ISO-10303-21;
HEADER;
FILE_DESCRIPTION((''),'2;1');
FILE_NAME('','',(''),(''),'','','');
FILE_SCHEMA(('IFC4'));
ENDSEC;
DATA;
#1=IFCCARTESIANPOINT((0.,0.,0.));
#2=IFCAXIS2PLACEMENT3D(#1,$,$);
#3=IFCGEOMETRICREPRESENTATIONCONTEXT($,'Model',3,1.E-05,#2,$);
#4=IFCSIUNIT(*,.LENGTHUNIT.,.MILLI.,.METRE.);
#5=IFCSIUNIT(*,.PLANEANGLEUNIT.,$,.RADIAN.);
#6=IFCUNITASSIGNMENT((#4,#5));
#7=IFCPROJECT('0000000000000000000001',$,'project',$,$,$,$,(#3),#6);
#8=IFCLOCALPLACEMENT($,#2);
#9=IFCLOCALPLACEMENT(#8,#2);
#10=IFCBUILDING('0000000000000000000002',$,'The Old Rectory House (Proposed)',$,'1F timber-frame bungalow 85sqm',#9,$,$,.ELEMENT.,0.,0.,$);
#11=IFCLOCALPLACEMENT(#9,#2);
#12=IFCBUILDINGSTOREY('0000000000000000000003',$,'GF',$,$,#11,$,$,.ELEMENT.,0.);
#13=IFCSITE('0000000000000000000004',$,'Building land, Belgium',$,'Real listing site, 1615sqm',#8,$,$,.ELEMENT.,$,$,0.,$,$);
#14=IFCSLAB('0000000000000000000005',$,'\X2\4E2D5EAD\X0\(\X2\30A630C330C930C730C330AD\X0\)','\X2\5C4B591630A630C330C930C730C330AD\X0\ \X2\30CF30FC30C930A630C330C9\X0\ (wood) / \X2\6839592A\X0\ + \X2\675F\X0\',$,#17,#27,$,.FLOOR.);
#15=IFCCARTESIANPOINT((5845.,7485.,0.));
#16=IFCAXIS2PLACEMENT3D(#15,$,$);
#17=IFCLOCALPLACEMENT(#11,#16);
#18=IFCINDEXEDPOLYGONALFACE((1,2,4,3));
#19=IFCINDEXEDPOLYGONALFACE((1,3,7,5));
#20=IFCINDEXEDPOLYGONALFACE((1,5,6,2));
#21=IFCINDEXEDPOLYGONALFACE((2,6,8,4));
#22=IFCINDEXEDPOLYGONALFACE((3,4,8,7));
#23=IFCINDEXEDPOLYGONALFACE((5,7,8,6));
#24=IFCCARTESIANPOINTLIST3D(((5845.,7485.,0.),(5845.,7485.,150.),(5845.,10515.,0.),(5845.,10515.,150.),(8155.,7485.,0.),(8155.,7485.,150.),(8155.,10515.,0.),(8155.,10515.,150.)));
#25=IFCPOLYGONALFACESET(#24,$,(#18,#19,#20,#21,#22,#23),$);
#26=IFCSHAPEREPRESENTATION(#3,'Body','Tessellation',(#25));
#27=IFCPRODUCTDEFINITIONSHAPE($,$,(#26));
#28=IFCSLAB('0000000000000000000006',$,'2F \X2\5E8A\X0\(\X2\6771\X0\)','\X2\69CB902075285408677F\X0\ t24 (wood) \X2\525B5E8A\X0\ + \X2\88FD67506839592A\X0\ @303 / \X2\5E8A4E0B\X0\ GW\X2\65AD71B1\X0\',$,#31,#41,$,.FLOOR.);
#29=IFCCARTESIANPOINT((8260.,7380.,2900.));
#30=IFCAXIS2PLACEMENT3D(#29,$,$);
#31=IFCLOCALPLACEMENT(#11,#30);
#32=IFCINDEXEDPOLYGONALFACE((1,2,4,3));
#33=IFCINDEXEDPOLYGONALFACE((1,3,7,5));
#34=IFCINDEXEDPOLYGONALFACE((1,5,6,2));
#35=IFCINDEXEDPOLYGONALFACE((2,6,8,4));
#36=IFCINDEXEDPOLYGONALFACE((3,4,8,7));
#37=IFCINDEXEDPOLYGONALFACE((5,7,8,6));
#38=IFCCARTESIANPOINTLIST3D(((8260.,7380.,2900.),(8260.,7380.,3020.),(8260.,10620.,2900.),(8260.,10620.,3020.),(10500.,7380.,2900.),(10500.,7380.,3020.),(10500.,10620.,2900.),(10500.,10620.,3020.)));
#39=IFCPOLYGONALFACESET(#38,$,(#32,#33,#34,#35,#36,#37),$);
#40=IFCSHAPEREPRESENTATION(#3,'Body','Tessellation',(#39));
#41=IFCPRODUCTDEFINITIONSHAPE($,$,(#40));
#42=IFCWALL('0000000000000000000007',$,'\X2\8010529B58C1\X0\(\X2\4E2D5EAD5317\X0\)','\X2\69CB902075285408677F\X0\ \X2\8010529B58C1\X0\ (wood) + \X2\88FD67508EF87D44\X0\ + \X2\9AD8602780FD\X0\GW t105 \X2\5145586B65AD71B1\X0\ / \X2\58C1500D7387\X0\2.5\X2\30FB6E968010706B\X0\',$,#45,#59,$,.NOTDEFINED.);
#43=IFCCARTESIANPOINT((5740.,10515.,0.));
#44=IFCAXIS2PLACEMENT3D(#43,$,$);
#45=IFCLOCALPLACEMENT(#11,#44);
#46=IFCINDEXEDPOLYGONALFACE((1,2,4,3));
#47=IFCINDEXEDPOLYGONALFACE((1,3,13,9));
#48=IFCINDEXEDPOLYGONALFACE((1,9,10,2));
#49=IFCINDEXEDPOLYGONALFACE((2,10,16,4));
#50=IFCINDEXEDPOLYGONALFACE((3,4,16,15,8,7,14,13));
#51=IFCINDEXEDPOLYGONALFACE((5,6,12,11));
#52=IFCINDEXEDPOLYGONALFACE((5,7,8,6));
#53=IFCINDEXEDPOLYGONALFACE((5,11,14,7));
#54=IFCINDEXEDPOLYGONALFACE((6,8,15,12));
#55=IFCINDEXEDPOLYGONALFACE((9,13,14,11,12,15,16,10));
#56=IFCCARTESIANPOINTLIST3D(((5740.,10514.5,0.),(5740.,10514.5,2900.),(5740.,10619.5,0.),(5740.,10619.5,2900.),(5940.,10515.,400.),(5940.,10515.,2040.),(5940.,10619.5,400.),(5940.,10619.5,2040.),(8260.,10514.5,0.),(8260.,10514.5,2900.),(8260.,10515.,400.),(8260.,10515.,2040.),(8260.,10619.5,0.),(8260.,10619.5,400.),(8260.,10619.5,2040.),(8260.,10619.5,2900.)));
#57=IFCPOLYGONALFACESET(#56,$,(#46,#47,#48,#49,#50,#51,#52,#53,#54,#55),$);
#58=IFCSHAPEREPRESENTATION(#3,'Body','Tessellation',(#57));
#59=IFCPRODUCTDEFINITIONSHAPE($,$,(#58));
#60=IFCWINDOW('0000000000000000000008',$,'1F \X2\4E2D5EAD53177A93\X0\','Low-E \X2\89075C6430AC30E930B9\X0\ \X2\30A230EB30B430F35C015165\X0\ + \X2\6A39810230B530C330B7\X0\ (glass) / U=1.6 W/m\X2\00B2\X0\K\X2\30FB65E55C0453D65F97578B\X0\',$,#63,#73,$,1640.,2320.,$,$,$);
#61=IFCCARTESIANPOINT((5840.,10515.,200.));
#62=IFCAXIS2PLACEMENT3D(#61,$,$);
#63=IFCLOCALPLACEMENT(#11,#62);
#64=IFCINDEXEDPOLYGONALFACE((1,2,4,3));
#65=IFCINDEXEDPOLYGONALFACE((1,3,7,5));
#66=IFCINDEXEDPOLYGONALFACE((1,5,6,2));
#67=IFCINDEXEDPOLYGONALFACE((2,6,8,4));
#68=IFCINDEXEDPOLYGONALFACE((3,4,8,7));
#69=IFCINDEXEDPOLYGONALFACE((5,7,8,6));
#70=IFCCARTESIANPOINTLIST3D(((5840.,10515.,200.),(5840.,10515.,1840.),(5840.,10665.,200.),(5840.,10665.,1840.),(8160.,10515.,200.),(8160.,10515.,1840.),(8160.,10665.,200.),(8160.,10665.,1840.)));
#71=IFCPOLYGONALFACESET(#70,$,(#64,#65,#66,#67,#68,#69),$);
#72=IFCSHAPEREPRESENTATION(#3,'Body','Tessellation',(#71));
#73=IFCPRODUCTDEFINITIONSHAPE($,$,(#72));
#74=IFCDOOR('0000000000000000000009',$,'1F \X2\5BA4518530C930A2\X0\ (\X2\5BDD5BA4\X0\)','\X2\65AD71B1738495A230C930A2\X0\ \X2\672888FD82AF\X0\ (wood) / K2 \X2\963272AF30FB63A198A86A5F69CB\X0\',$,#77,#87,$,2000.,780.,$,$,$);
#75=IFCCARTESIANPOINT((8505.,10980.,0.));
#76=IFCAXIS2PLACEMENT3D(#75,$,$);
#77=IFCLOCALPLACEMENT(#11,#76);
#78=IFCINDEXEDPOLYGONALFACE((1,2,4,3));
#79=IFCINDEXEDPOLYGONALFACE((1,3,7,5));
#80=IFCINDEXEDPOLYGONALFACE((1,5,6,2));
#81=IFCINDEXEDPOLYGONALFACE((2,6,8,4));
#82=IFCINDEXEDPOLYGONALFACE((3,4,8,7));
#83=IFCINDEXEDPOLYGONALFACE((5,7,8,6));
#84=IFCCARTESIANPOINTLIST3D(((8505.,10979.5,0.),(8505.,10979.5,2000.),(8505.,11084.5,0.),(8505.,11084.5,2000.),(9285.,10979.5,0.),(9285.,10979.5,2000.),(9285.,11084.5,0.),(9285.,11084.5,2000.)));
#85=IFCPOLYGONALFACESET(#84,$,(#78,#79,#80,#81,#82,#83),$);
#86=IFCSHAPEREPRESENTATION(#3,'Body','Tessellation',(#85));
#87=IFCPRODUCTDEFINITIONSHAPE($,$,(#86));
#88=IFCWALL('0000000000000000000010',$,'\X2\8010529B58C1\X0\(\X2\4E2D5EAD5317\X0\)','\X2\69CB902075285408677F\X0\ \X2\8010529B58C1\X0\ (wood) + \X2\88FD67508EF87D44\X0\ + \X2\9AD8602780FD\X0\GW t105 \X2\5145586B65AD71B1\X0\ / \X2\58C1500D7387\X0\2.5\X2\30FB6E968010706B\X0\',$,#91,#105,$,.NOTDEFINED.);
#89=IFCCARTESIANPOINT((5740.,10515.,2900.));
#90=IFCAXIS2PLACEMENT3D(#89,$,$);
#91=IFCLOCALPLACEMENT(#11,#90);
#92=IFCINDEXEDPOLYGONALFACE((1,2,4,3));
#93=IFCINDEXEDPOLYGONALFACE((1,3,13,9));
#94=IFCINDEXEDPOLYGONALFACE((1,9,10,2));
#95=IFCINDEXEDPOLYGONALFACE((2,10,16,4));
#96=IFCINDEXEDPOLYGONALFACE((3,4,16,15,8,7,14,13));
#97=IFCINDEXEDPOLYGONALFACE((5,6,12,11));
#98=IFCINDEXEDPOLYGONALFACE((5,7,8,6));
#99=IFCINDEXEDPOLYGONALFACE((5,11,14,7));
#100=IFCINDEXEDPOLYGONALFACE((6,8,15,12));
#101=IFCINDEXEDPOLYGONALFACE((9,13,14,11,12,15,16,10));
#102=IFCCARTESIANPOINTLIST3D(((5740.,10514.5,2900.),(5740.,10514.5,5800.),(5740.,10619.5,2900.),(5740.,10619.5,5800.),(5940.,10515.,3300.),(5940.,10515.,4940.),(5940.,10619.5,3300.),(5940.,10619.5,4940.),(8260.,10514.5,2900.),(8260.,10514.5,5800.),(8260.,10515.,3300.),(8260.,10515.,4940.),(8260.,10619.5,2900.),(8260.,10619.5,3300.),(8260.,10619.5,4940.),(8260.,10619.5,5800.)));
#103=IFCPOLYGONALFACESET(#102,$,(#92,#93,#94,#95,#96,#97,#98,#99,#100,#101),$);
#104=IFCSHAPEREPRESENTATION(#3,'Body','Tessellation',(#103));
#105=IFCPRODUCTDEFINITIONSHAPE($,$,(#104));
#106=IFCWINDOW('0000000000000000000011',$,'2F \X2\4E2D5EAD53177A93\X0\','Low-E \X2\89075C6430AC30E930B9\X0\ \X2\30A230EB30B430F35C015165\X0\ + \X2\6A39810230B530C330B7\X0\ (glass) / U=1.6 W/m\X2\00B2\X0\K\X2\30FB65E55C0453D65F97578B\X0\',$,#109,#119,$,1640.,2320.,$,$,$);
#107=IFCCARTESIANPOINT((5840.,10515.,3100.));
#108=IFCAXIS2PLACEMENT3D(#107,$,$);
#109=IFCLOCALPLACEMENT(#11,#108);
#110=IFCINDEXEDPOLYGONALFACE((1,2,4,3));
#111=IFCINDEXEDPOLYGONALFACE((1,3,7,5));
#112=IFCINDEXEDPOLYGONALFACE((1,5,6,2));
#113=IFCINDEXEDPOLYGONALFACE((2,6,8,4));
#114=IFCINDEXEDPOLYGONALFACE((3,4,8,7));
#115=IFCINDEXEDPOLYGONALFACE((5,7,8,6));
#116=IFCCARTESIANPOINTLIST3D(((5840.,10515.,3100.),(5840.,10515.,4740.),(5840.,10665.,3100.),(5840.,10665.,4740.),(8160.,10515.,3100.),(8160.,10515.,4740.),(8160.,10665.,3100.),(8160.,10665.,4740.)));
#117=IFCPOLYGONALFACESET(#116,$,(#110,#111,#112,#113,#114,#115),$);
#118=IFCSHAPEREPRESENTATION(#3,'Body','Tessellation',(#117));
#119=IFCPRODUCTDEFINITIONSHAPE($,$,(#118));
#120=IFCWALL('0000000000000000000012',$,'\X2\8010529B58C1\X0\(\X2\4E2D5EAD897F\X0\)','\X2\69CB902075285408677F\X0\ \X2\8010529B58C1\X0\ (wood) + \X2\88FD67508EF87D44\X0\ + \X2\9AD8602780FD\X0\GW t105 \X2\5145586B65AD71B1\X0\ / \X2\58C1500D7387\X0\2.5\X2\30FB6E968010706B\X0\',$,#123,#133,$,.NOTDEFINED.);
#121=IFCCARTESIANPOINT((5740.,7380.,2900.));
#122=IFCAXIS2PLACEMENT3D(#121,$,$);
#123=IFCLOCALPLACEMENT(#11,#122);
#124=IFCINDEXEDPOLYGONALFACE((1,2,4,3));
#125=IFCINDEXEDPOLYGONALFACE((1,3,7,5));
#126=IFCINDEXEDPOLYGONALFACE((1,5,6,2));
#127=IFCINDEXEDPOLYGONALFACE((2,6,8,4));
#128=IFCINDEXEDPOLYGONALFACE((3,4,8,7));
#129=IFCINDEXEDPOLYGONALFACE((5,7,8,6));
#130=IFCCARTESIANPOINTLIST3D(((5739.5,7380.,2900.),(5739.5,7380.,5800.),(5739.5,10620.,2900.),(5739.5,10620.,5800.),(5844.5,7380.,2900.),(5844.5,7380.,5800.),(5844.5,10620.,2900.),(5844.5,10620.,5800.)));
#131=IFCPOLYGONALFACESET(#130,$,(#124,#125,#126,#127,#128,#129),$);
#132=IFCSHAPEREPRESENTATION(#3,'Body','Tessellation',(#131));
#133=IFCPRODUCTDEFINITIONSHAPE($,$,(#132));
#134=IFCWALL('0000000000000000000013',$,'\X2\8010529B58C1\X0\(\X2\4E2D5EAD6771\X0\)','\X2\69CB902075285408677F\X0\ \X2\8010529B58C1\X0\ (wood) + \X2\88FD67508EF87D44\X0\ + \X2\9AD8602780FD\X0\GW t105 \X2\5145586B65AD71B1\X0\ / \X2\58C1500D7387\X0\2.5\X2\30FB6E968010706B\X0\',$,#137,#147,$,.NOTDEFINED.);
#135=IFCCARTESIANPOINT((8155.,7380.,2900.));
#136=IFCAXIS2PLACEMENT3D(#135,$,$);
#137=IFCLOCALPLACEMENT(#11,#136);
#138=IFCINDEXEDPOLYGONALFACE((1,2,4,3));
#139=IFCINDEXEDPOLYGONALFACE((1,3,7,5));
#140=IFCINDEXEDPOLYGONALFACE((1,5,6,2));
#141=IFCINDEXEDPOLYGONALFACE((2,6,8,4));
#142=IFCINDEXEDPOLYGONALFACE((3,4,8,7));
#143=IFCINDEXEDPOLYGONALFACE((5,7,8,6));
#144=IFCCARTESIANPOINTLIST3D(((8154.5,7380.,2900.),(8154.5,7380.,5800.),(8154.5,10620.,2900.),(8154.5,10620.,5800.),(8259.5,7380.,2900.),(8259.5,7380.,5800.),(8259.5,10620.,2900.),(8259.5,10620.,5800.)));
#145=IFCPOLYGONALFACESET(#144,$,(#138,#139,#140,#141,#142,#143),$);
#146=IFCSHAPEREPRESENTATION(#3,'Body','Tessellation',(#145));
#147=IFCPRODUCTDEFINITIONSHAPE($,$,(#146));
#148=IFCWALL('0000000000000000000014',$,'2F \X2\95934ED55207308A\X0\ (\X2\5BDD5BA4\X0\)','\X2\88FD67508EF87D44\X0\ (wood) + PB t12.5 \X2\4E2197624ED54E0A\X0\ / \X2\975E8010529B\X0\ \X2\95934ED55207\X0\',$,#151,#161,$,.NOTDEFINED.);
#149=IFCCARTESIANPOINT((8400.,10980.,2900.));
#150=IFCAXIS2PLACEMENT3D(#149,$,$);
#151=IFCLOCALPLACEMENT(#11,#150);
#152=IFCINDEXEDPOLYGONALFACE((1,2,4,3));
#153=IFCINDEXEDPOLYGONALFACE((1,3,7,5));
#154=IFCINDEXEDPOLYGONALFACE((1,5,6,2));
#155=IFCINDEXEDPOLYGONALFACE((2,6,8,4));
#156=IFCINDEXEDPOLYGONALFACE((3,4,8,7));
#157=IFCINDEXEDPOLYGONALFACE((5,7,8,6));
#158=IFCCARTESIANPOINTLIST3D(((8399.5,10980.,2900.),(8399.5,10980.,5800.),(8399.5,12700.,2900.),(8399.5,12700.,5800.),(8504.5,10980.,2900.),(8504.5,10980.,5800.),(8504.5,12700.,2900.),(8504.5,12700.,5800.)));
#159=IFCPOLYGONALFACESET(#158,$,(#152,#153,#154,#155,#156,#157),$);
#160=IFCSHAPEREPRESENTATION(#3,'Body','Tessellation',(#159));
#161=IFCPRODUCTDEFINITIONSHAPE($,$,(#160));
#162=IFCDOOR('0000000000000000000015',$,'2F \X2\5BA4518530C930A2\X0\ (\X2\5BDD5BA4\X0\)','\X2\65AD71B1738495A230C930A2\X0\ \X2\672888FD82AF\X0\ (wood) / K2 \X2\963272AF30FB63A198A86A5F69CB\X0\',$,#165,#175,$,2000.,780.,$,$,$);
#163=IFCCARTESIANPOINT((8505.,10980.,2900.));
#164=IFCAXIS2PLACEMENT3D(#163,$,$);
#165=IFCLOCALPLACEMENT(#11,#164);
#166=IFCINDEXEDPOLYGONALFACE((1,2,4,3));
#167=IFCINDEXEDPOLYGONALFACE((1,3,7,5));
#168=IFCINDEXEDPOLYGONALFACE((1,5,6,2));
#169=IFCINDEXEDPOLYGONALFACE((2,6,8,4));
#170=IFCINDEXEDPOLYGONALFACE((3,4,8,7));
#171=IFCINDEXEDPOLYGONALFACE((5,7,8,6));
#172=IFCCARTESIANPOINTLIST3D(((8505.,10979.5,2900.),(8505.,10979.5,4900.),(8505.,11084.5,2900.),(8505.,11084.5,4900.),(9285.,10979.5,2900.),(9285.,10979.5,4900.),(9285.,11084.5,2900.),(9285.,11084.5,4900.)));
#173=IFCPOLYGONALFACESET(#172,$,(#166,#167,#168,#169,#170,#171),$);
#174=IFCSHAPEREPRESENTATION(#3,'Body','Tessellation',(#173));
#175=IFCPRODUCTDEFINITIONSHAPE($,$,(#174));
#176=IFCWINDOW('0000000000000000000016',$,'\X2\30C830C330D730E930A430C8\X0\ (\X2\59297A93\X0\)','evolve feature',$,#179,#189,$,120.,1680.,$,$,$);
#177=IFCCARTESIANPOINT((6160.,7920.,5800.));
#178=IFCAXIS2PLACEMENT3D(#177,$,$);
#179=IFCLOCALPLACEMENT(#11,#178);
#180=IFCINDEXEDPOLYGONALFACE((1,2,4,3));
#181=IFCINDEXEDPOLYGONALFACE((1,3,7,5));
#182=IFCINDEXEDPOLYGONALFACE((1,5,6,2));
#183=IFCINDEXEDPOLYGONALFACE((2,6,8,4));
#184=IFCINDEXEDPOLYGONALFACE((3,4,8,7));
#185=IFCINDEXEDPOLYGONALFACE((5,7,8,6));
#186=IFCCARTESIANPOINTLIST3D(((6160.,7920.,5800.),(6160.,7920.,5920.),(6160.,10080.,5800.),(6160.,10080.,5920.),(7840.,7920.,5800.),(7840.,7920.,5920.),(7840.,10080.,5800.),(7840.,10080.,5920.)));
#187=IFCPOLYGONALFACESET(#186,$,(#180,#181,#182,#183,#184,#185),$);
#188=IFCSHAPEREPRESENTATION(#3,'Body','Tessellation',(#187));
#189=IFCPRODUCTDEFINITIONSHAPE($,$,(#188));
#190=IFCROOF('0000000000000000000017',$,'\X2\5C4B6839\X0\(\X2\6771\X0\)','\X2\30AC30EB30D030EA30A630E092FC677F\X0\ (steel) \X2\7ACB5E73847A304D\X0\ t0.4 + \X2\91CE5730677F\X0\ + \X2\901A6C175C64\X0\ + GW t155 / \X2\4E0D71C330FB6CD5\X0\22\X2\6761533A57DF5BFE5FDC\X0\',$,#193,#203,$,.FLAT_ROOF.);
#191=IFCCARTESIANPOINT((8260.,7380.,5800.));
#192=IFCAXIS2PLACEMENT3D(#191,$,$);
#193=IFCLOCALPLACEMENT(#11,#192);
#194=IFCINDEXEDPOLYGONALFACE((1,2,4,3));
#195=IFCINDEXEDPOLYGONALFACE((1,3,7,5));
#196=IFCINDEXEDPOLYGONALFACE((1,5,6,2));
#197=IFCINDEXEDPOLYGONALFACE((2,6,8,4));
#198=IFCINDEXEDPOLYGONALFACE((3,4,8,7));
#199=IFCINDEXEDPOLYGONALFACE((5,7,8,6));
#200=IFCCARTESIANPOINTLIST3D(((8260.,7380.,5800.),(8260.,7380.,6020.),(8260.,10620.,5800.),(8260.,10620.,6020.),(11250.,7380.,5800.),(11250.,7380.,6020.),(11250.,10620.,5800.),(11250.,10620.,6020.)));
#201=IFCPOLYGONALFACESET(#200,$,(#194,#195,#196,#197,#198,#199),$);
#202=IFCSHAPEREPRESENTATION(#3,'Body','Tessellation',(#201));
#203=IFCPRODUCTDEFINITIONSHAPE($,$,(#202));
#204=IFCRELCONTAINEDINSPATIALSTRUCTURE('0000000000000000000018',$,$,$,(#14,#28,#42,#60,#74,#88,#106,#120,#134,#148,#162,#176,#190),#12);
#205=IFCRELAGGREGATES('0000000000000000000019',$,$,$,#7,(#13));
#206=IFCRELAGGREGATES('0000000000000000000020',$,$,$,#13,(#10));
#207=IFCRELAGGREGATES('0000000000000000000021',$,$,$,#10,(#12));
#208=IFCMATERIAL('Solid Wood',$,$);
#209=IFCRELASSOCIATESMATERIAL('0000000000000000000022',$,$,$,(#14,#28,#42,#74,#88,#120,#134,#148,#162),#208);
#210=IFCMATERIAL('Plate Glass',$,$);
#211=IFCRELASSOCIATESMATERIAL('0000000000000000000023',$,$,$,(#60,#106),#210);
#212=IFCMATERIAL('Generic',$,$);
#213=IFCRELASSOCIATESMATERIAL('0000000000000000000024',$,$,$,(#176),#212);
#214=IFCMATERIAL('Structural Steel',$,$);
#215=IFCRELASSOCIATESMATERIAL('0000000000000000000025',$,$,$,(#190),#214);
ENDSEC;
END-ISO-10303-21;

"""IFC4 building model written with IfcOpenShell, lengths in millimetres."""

from ifc_helpers import new_model, si_unit, frame, frame_2d, origin, place, context, project, spatial, rectangle, extrude, material, element, fill, save


model = new_model("IFC4")

# Units and contexts
model_context = context("Model", 3, precision=1e-05, world=origin())
ifc_project = project(units=[si_unit("LENGTHUNIT", "METRE", prefix="MILLI"), si_unit("PLANEANGLEUNIT", "RADIAN")], contexts=[model_context])

# Site, building, storey
site_placement = place(None, origin())
site = spatial("IfcSite", under=ifc_project, at=site_placement, Name="Building land, Belgium", ObjectType="Real listing site, 1615sqm", CompositionType="ELEMENT", RefElevation=0.0)
building_placement = place(site_placement, origin())
building = spatial("IfcBuilding", under=site, at=building_placement, Name="The Old Rectory House (Proposed)", ObjectType="1F timber-frame bungalow 85sqm", CompositionType="ELEMENT", ElevationOfRefHeight=0.0, ElevationOfTerrain=0.0)
storey_placement = place(building_placement, origin())
storey = spatial("IfcBuildingStorey", under=building, at=storey_placement, Name="GF", CompositionType="ELEMENT", Elevation=0.0)

# Slabs
ifc_material_1 = material(Name="Solid Wood")
slab_1_placement = place(storey_placement, frame((5845.0, 7485.0, 0.0)))
element("IfcSlab", 1, at=slab_1_placement, inside=storey, material=ifc_material_1, Name="中庭(ウッドデッキ)", Description="屋外ウッドデッキ ハードウッド (wood) / 根太 + 束", PredefinedType="FLOOR", context=model_context, shape_type="SweptSolid", body=[
    extrude(rectangle(XDim=2310.0, YDim=3030.0, at=frame_2d((1155.0, 1515.0))), frame((5845.0, 7485.0, 0.0)), (0.0, 0.0, 1.0), 150.0),
])
slab_2_placement = place(storey_placement, frame((8260.0, 7380.0, 2900.0)))
element("IfcSlab", 2, at=slab_2_placement, inside=storey, material=ifc_material_1, Name="2F 床(東)", Description="構造用合板 t24 (wood) 剛床 + 製材根太 @303 / 床下 GW断熱", PredefinedType="FLOOR", context=model_context, shape_type="SweptSolid", body=[
    extrude(rectangle(XDim=2240.0, YDim=3240.0, at=frame_2d((1120.0, 1620.0))), frame((8260.0, 7380.0, 2900.0)), (0.0, 0.0, 1.0), 120.0),
])

# Wall, opening, window
wall_1_placement = place(storey_placement, frame((5740.0, 10515.0, 0.0)))
wall_1 = element("IfcWall", 3, at=wall_1_placement, inside=storey, material=ifc_material_1, Name="耐力壁(中庭北)", Description="構造用合板 耐力壁 (wood) + 製材軸組 + 高性能GW t105 充填断熱 / 壁倍率2.5・準耐火", PredefinedType="NOTDEFINED", context=model_context, shape_type="SweptSolid", body=[
    extrude(rectangle(XDim=2520.0, YDim=105.0, at=frame_2d((1260.0, 52.0))), frame((5740.0, 10515.0, 0.0)), (0.0, 0.0, 1.0), 2900.0),
])
opening_1_placement = place(storey_placement, frame((5840.0, 10515.0, 200.0)))
opening_1 = element("IfcOpeningElement", 4, at=opening_1_placement, cuts=wall_1, PredefinedType="NOTDEFINED", context=model_context, shape_type="SweptSolid", body=[
    extrude(rectangle(XDim=2320.0, YDim=150.0, at=frame_2d((1160.0, 75.0))), frame((5840.0, 10515.0, 200.0)), (0.0, 0.0, 1.0), 1640.0),
])
ifc_material_2 = material(Name="Plate Glass")
window_1_placement = place(storey_placement, frame((5840.0, 10515.0, 200.0)))
window_1 = element("IfcWindow", 5, at=window_1_placement, inside=storey, material=ifc_material_2, Name="1F 中庭北窓", Description="Low-E 複層ガラス アルゴン封入 + 樹脂サッシ (glass) / U=1.6 W/m²K・日射取得型", OverallHeight=1640.0, OverallWidth=2320.0, context=model_context, shape_type="SweptSolid", body=[
    extrude(rectangle(XDim=2320.0, YDim=150.0, at=frame_2d((1160.0, 75.0))), frame((5840.0, 10515.0, 200.0)), (0.0, 0.0, 1.0), 1640.0),
])
fill(opening_1, window_1)

# Door
door_1_placement = place(storey_placement, frame((8505.0, 10980.0, 0.0)))
element("IfcDoor", 6, at=door_1_placement, inside=storey, material=ifc_material_1, Name="1F 室内ドア (寝室)", Description="断熱玄関ドア 木製芯 (wood) / K2 防犯・採風機構", OverallHeight=2000.0, OverallWidth=780.0, context=model_context, shape_type="SweptSolid", body=[
    extrude(rectangle(XDim=780.0, YDim=105.0, at=frame_2d((390.0, 52.0))), frame((8505.0, 10980.0, 0.0)), (0.0, 0.0, 1.0), 2000.0),
])

# Wall, opening, window
wall_2_placement = place(storey_placement, frame((5740.0, 10515.0, 2900.0)))
wall_2 = element("IfcWall", 7, at=wall_2_placement, inside=storey, material=ifc_material_1, Name="耐力壁(中庭北)", Description="構造用合板 耐力壁 (wood) + 製材軸組 + 高性能GW t105 充填断熱 / 壁倍率2.5・準耐火", PredefinedType="NOTDEFINED", context=model_context, shape_type="SweptSolid", body=[
    extrude(rectangle(XDim=2520.0, YDim=105.0, at=frame_2d((1260.0, 52.0))), frame((5740.0, 10515.0, 2900.0)), (0.0, 0.0, 1.0), 2900.0),
])
opening_2_placement = place(storey_placement, frame((5840.0, 10515.0, 3100.0)))
opening_2 = element("IfcOpeningElement", 8, at=opening_2_placement, cuts=wall_2, PredefinedType="NOTDEFINED", context=model_context, shape_type="SweptSolid", body=[
    extrude(rectangle(XDim=2320.0, YDim=150.0, at=frame_2d((1160.0, 75.0))), frame((5840.0, 10515.0, 3100.0)), (0.0, 0.0, 1.0), 1640.0),
])
window_2_placement = place(storey_placement, frame((5840.0, 10515.0, 3100.0)))
window_2 = element("IfcWindow", 9, at=window_2_placement, inside=storey, material=ifc_material_2, Name="2F 中庭北窓", Description="Low-E 複層ガラス アルゴン封入 + 樹脂サッシ (glass) / U=1.6 W/m²K・日射取得型", OverallHeight=1640.0, OverallWidth=2320.0, context=model_context, shape_type="SweptSolid", body=[
    extrude(rectangle(XDim=2320.0, YDim=150.0, at=frame_2d((1160.0, 75.0))), frame((5840.0, 10515.0, 3100.0)), (0.0, 0.0, 1.0), 1640.0),
])
fill(opening_2, window_2)

# Walls
wall_3_placement = place(storey_placement, frame((5740.0, 7380.0, 2900.0)))
element("IfcWall", 10, at=wall_3_placement, inside=storey, material=ifc_material_1, Name="耐力壁(中庭西)", Description="構造用合板 耐力壁 (wood) + 製材軸組 + 高性能GW t105 充填断熱 / 壁倍率2.5・準耐火", PredefinedType="NOTDEFINED", context=model_context, shape_type="SweptSolid", body=[
    extrude(rectangle(XDim=105.0, YDim=3240.0, at=frame_2d((52.0, 1620.0))), frame((5740.0, 7380.0, 2900.0)), (0.0, 0.0, 1.0), 2900.0),
])
wall_4_placement = place(storey_placement, frame((8155.0, 7380.0, 2900.0)))
element("IfcWall", 11, at=wall_4_placement, inside=storey, material=ifc_material_1, Name="耐力壁(中庭東)", Description="構造用合板 耐力壁 (wood) + 製材軸組 + 高性能GW t105 充填断熱 / 壁倍率2.5・準耐火", PredefinedType="NOTDEFINED", context=model_context, shape_type="SweptSolid", body=[
    extrude(rectangle(XDim=105.0, YDim=3240.0, at=frame_2d((52.0, 1620.0))), frame((8155.0, 7380.0, 2900.0)), (0.0, 0.0, 1.0), 2900.0),
])
wall_5_placement = place(storey_placement, frame((8400.0, 10980.0, 2900.0)))
element("IfcWall", 12, at=wall_5_placement, inside=storey, material=ifc_material_1, Name="2F 間仕切り (寝室)", Description="製材軸組 (wood) + PB t12.5 両面仕上 / 非耐力 間仕切", PredefinedType="NOTDEFINED", context=model_context, shape_type="SweptSolid", body=[
    extrude(rectangle(XDim=105.0, YDim=1720.0, at=frame_2d((52.0, 860.0))), frame((8400.0, 10980.0, 2900.0)), (0.0, 0.0, 1.0), 2900.0),
])

# Door
door_2_placement = place(storey_placement, frame((8505.0, 10980.0, 2900.0)))
element("IfcDoor", 13, at=door_2_placement, inside=storey, material=ifc_material_1, Name="2F 室内ドア (寝室)", Description="断熱玄関ドア 木製芯 (wood) / K2 防犯・採風機構", OverallHeight=2000.0, OverallWidth=780.0, context=model_context, shape_type="SweptSolid", body=[
    extrude(rectangle(XDim=780.0, YDim=105.0, at=frame_2d((390.0, 52.0))), frame((8505.0, 10980.0, 2900.0)), (0.0, 0.0, 1.0), 2000.0),
])

# Window
ifc_material_3 = material(Name="Generic")
window_3_placement = place(storey_placement, frame((6160.0, 7920.0, 5800.0)))
element("IfcWindow", 14, at=window_3_placement, inside=storey, material=ifc_material_3, Name="トップライト (天窓)", Description="evolve feature", OverallHeight=120.0, OverallWidth=1680.0, context=model_context, shape_type="SweptSolid", body=[
    extrude(rectangle(XDim=1680.0, YDim=2160.0, at=frame_2d((840.0, 1080.0))), frame((6160.0, 7920.0, 5800.0)), (0.0, 0.0, 1.0), 120.0),
])

# Roof
ifc_material_4 = material(Name="Structural Steel")
roof_placement = place(storey_placement, frame((8260.0, 7380.0, 5800.0)))
element("IfcRoof", 15, at=roof_placement, inside=storey, material=ifc_material_4, Name="屋根(東)", Description="ガルバリウム鋼板 (steel) 立平葺き t0.4 + 野地板 + 通気層 + GW t155 / 不燃・法22条区域対応", PredefinedType="FLAT_ROOF", context=model_context, shape_type="SweptSolid", body=[
    extrude(rectangle(XDim=2990.0, YDim=3240.0, at=frame_2d((1495.0, 1620.0))), frame((8260.0, 7380.0, 5800.0)), (0.0, 0.0, 1.0), 220.0),
])

save(model, "model.ifc")
